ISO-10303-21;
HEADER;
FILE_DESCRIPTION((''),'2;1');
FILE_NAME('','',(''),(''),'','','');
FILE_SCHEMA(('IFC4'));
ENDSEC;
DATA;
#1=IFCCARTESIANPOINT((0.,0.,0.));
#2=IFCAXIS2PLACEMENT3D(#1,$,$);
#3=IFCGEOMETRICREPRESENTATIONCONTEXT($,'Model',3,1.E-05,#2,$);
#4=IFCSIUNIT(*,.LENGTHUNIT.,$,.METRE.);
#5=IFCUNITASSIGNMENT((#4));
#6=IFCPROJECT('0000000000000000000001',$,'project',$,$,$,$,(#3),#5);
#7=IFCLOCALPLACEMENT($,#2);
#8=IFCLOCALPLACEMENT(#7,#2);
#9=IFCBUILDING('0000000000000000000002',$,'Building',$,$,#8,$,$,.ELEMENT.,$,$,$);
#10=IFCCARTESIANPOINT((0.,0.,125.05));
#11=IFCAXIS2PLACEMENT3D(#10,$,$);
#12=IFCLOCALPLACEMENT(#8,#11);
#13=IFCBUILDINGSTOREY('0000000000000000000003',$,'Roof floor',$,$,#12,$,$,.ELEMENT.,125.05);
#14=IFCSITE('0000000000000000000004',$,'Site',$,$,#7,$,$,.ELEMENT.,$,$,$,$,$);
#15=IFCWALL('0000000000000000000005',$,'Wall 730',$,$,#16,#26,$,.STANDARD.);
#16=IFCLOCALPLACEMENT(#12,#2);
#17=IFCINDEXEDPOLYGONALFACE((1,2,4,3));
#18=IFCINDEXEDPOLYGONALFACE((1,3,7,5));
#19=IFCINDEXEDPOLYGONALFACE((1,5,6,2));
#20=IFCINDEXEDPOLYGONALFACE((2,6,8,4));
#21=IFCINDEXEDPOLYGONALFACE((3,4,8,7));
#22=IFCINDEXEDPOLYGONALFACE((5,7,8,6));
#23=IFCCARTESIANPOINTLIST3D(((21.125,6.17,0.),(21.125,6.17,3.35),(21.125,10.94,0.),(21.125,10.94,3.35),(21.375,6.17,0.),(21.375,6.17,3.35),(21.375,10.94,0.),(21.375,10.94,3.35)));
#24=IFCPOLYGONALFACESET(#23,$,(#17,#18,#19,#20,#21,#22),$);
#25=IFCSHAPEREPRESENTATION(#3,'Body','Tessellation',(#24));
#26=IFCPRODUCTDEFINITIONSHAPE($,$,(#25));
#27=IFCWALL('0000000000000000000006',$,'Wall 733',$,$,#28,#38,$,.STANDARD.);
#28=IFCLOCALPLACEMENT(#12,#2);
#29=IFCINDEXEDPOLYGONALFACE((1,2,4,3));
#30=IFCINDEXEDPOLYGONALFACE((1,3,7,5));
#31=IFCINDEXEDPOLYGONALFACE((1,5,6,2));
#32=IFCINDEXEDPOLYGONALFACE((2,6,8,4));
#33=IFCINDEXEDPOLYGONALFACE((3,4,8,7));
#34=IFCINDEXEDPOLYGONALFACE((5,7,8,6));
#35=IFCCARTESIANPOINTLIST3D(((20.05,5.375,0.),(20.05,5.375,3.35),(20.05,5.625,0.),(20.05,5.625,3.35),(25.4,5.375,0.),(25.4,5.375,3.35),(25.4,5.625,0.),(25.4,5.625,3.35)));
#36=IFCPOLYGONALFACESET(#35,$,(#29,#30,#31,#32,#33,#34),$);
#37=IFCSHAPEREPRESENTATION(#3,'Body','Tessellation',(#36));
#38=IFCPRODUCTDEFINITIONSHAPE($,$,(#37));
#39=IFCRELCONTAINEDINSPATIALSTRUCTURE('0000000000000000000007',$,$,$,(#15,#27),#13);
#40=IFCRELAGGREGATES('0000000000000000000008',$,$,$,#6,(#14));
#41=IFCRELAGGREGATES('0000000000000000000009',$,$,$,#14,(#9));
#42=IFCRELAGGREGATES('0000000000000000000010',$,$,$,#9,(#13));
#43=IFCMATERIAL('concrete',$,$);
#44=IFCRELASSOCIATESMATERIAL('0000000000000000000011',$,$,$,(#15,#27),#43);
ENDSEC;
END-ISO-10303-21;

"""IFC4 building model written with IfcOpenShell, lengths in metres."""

from ifc_helpers import new_model, si_unit, frame, frame_2d, origin, place, context, project, spatial, rectangle, extrude, material, element, save


model = new_model("IFC4")

# Units and contexts
model_context = context("Model", 3, precision=1e-05, world=origin())
ifc_project = project(units=[si_unit("LENGTHUNIT", "METRE")], contexts=[model_context])

# Site, building, storey
site_placement = place(None, origin())
site = spatial("IfcSite", under=ifc_project, at=site_placement, Name="Site", CompositionType="ELEMENT")
building_placement = place(site_placement, origin())
building = spatial("IfcBuilding", under=site, at=building_placement, Name="Building", CompositionType="ELEMENT")
storey_placement = place(building_placement, frame((0.0, 0.0, 125.05)))
storey = spatial("IfcBuildingStorey", under=building, at=storey_placement, Name="Roof floor", CompositionType="ELEMENT", Elevation=125.05)

# Shared definitions
ifc_material = material(Name="concrete")

# Walls
wall_1_placement = place(storey_placement, frame((21.25, 6.17, 0.0), z_axis=(0.0, 0.0, 1.0), x_axis=(0.0, 1.0, 0.0)))
element("IfcWall", 1, at=wall_1_placement, inside=storey, material=ifc_material, Name="Wall 730", PredefinedType="STANDARD", context=model_context, shape_type="SweptSolid", body=[
    extrude(rectangle(XDim=4.77, YDim=0.25, at=frame_2d((2.385, 0.0))), origin(), (0.0, 0.0, 1.0), 3.35),
])
wall_2_placement = place(storey_placement, frame((20.05, 5.5, 0.0), z_axis=(0.0, 0.0, 1.0), x_axis=(1.0, 0.0, 0.0)))
element("IfcWall", 2, at=wall_2_placement, inside=storey, material=ifc_material, Name="Wall 733", PredefinedType="STANDARD", context=model_context, shape_type="SweptSolid", body=[
    extrude(rectangle(XDim=5.35, YDim=0.25, at=frame_2d((2.675, 0.0))), origin(), (0.0, 0.0, 1.0), 3.35),
])

save(model, "model.ifc")
